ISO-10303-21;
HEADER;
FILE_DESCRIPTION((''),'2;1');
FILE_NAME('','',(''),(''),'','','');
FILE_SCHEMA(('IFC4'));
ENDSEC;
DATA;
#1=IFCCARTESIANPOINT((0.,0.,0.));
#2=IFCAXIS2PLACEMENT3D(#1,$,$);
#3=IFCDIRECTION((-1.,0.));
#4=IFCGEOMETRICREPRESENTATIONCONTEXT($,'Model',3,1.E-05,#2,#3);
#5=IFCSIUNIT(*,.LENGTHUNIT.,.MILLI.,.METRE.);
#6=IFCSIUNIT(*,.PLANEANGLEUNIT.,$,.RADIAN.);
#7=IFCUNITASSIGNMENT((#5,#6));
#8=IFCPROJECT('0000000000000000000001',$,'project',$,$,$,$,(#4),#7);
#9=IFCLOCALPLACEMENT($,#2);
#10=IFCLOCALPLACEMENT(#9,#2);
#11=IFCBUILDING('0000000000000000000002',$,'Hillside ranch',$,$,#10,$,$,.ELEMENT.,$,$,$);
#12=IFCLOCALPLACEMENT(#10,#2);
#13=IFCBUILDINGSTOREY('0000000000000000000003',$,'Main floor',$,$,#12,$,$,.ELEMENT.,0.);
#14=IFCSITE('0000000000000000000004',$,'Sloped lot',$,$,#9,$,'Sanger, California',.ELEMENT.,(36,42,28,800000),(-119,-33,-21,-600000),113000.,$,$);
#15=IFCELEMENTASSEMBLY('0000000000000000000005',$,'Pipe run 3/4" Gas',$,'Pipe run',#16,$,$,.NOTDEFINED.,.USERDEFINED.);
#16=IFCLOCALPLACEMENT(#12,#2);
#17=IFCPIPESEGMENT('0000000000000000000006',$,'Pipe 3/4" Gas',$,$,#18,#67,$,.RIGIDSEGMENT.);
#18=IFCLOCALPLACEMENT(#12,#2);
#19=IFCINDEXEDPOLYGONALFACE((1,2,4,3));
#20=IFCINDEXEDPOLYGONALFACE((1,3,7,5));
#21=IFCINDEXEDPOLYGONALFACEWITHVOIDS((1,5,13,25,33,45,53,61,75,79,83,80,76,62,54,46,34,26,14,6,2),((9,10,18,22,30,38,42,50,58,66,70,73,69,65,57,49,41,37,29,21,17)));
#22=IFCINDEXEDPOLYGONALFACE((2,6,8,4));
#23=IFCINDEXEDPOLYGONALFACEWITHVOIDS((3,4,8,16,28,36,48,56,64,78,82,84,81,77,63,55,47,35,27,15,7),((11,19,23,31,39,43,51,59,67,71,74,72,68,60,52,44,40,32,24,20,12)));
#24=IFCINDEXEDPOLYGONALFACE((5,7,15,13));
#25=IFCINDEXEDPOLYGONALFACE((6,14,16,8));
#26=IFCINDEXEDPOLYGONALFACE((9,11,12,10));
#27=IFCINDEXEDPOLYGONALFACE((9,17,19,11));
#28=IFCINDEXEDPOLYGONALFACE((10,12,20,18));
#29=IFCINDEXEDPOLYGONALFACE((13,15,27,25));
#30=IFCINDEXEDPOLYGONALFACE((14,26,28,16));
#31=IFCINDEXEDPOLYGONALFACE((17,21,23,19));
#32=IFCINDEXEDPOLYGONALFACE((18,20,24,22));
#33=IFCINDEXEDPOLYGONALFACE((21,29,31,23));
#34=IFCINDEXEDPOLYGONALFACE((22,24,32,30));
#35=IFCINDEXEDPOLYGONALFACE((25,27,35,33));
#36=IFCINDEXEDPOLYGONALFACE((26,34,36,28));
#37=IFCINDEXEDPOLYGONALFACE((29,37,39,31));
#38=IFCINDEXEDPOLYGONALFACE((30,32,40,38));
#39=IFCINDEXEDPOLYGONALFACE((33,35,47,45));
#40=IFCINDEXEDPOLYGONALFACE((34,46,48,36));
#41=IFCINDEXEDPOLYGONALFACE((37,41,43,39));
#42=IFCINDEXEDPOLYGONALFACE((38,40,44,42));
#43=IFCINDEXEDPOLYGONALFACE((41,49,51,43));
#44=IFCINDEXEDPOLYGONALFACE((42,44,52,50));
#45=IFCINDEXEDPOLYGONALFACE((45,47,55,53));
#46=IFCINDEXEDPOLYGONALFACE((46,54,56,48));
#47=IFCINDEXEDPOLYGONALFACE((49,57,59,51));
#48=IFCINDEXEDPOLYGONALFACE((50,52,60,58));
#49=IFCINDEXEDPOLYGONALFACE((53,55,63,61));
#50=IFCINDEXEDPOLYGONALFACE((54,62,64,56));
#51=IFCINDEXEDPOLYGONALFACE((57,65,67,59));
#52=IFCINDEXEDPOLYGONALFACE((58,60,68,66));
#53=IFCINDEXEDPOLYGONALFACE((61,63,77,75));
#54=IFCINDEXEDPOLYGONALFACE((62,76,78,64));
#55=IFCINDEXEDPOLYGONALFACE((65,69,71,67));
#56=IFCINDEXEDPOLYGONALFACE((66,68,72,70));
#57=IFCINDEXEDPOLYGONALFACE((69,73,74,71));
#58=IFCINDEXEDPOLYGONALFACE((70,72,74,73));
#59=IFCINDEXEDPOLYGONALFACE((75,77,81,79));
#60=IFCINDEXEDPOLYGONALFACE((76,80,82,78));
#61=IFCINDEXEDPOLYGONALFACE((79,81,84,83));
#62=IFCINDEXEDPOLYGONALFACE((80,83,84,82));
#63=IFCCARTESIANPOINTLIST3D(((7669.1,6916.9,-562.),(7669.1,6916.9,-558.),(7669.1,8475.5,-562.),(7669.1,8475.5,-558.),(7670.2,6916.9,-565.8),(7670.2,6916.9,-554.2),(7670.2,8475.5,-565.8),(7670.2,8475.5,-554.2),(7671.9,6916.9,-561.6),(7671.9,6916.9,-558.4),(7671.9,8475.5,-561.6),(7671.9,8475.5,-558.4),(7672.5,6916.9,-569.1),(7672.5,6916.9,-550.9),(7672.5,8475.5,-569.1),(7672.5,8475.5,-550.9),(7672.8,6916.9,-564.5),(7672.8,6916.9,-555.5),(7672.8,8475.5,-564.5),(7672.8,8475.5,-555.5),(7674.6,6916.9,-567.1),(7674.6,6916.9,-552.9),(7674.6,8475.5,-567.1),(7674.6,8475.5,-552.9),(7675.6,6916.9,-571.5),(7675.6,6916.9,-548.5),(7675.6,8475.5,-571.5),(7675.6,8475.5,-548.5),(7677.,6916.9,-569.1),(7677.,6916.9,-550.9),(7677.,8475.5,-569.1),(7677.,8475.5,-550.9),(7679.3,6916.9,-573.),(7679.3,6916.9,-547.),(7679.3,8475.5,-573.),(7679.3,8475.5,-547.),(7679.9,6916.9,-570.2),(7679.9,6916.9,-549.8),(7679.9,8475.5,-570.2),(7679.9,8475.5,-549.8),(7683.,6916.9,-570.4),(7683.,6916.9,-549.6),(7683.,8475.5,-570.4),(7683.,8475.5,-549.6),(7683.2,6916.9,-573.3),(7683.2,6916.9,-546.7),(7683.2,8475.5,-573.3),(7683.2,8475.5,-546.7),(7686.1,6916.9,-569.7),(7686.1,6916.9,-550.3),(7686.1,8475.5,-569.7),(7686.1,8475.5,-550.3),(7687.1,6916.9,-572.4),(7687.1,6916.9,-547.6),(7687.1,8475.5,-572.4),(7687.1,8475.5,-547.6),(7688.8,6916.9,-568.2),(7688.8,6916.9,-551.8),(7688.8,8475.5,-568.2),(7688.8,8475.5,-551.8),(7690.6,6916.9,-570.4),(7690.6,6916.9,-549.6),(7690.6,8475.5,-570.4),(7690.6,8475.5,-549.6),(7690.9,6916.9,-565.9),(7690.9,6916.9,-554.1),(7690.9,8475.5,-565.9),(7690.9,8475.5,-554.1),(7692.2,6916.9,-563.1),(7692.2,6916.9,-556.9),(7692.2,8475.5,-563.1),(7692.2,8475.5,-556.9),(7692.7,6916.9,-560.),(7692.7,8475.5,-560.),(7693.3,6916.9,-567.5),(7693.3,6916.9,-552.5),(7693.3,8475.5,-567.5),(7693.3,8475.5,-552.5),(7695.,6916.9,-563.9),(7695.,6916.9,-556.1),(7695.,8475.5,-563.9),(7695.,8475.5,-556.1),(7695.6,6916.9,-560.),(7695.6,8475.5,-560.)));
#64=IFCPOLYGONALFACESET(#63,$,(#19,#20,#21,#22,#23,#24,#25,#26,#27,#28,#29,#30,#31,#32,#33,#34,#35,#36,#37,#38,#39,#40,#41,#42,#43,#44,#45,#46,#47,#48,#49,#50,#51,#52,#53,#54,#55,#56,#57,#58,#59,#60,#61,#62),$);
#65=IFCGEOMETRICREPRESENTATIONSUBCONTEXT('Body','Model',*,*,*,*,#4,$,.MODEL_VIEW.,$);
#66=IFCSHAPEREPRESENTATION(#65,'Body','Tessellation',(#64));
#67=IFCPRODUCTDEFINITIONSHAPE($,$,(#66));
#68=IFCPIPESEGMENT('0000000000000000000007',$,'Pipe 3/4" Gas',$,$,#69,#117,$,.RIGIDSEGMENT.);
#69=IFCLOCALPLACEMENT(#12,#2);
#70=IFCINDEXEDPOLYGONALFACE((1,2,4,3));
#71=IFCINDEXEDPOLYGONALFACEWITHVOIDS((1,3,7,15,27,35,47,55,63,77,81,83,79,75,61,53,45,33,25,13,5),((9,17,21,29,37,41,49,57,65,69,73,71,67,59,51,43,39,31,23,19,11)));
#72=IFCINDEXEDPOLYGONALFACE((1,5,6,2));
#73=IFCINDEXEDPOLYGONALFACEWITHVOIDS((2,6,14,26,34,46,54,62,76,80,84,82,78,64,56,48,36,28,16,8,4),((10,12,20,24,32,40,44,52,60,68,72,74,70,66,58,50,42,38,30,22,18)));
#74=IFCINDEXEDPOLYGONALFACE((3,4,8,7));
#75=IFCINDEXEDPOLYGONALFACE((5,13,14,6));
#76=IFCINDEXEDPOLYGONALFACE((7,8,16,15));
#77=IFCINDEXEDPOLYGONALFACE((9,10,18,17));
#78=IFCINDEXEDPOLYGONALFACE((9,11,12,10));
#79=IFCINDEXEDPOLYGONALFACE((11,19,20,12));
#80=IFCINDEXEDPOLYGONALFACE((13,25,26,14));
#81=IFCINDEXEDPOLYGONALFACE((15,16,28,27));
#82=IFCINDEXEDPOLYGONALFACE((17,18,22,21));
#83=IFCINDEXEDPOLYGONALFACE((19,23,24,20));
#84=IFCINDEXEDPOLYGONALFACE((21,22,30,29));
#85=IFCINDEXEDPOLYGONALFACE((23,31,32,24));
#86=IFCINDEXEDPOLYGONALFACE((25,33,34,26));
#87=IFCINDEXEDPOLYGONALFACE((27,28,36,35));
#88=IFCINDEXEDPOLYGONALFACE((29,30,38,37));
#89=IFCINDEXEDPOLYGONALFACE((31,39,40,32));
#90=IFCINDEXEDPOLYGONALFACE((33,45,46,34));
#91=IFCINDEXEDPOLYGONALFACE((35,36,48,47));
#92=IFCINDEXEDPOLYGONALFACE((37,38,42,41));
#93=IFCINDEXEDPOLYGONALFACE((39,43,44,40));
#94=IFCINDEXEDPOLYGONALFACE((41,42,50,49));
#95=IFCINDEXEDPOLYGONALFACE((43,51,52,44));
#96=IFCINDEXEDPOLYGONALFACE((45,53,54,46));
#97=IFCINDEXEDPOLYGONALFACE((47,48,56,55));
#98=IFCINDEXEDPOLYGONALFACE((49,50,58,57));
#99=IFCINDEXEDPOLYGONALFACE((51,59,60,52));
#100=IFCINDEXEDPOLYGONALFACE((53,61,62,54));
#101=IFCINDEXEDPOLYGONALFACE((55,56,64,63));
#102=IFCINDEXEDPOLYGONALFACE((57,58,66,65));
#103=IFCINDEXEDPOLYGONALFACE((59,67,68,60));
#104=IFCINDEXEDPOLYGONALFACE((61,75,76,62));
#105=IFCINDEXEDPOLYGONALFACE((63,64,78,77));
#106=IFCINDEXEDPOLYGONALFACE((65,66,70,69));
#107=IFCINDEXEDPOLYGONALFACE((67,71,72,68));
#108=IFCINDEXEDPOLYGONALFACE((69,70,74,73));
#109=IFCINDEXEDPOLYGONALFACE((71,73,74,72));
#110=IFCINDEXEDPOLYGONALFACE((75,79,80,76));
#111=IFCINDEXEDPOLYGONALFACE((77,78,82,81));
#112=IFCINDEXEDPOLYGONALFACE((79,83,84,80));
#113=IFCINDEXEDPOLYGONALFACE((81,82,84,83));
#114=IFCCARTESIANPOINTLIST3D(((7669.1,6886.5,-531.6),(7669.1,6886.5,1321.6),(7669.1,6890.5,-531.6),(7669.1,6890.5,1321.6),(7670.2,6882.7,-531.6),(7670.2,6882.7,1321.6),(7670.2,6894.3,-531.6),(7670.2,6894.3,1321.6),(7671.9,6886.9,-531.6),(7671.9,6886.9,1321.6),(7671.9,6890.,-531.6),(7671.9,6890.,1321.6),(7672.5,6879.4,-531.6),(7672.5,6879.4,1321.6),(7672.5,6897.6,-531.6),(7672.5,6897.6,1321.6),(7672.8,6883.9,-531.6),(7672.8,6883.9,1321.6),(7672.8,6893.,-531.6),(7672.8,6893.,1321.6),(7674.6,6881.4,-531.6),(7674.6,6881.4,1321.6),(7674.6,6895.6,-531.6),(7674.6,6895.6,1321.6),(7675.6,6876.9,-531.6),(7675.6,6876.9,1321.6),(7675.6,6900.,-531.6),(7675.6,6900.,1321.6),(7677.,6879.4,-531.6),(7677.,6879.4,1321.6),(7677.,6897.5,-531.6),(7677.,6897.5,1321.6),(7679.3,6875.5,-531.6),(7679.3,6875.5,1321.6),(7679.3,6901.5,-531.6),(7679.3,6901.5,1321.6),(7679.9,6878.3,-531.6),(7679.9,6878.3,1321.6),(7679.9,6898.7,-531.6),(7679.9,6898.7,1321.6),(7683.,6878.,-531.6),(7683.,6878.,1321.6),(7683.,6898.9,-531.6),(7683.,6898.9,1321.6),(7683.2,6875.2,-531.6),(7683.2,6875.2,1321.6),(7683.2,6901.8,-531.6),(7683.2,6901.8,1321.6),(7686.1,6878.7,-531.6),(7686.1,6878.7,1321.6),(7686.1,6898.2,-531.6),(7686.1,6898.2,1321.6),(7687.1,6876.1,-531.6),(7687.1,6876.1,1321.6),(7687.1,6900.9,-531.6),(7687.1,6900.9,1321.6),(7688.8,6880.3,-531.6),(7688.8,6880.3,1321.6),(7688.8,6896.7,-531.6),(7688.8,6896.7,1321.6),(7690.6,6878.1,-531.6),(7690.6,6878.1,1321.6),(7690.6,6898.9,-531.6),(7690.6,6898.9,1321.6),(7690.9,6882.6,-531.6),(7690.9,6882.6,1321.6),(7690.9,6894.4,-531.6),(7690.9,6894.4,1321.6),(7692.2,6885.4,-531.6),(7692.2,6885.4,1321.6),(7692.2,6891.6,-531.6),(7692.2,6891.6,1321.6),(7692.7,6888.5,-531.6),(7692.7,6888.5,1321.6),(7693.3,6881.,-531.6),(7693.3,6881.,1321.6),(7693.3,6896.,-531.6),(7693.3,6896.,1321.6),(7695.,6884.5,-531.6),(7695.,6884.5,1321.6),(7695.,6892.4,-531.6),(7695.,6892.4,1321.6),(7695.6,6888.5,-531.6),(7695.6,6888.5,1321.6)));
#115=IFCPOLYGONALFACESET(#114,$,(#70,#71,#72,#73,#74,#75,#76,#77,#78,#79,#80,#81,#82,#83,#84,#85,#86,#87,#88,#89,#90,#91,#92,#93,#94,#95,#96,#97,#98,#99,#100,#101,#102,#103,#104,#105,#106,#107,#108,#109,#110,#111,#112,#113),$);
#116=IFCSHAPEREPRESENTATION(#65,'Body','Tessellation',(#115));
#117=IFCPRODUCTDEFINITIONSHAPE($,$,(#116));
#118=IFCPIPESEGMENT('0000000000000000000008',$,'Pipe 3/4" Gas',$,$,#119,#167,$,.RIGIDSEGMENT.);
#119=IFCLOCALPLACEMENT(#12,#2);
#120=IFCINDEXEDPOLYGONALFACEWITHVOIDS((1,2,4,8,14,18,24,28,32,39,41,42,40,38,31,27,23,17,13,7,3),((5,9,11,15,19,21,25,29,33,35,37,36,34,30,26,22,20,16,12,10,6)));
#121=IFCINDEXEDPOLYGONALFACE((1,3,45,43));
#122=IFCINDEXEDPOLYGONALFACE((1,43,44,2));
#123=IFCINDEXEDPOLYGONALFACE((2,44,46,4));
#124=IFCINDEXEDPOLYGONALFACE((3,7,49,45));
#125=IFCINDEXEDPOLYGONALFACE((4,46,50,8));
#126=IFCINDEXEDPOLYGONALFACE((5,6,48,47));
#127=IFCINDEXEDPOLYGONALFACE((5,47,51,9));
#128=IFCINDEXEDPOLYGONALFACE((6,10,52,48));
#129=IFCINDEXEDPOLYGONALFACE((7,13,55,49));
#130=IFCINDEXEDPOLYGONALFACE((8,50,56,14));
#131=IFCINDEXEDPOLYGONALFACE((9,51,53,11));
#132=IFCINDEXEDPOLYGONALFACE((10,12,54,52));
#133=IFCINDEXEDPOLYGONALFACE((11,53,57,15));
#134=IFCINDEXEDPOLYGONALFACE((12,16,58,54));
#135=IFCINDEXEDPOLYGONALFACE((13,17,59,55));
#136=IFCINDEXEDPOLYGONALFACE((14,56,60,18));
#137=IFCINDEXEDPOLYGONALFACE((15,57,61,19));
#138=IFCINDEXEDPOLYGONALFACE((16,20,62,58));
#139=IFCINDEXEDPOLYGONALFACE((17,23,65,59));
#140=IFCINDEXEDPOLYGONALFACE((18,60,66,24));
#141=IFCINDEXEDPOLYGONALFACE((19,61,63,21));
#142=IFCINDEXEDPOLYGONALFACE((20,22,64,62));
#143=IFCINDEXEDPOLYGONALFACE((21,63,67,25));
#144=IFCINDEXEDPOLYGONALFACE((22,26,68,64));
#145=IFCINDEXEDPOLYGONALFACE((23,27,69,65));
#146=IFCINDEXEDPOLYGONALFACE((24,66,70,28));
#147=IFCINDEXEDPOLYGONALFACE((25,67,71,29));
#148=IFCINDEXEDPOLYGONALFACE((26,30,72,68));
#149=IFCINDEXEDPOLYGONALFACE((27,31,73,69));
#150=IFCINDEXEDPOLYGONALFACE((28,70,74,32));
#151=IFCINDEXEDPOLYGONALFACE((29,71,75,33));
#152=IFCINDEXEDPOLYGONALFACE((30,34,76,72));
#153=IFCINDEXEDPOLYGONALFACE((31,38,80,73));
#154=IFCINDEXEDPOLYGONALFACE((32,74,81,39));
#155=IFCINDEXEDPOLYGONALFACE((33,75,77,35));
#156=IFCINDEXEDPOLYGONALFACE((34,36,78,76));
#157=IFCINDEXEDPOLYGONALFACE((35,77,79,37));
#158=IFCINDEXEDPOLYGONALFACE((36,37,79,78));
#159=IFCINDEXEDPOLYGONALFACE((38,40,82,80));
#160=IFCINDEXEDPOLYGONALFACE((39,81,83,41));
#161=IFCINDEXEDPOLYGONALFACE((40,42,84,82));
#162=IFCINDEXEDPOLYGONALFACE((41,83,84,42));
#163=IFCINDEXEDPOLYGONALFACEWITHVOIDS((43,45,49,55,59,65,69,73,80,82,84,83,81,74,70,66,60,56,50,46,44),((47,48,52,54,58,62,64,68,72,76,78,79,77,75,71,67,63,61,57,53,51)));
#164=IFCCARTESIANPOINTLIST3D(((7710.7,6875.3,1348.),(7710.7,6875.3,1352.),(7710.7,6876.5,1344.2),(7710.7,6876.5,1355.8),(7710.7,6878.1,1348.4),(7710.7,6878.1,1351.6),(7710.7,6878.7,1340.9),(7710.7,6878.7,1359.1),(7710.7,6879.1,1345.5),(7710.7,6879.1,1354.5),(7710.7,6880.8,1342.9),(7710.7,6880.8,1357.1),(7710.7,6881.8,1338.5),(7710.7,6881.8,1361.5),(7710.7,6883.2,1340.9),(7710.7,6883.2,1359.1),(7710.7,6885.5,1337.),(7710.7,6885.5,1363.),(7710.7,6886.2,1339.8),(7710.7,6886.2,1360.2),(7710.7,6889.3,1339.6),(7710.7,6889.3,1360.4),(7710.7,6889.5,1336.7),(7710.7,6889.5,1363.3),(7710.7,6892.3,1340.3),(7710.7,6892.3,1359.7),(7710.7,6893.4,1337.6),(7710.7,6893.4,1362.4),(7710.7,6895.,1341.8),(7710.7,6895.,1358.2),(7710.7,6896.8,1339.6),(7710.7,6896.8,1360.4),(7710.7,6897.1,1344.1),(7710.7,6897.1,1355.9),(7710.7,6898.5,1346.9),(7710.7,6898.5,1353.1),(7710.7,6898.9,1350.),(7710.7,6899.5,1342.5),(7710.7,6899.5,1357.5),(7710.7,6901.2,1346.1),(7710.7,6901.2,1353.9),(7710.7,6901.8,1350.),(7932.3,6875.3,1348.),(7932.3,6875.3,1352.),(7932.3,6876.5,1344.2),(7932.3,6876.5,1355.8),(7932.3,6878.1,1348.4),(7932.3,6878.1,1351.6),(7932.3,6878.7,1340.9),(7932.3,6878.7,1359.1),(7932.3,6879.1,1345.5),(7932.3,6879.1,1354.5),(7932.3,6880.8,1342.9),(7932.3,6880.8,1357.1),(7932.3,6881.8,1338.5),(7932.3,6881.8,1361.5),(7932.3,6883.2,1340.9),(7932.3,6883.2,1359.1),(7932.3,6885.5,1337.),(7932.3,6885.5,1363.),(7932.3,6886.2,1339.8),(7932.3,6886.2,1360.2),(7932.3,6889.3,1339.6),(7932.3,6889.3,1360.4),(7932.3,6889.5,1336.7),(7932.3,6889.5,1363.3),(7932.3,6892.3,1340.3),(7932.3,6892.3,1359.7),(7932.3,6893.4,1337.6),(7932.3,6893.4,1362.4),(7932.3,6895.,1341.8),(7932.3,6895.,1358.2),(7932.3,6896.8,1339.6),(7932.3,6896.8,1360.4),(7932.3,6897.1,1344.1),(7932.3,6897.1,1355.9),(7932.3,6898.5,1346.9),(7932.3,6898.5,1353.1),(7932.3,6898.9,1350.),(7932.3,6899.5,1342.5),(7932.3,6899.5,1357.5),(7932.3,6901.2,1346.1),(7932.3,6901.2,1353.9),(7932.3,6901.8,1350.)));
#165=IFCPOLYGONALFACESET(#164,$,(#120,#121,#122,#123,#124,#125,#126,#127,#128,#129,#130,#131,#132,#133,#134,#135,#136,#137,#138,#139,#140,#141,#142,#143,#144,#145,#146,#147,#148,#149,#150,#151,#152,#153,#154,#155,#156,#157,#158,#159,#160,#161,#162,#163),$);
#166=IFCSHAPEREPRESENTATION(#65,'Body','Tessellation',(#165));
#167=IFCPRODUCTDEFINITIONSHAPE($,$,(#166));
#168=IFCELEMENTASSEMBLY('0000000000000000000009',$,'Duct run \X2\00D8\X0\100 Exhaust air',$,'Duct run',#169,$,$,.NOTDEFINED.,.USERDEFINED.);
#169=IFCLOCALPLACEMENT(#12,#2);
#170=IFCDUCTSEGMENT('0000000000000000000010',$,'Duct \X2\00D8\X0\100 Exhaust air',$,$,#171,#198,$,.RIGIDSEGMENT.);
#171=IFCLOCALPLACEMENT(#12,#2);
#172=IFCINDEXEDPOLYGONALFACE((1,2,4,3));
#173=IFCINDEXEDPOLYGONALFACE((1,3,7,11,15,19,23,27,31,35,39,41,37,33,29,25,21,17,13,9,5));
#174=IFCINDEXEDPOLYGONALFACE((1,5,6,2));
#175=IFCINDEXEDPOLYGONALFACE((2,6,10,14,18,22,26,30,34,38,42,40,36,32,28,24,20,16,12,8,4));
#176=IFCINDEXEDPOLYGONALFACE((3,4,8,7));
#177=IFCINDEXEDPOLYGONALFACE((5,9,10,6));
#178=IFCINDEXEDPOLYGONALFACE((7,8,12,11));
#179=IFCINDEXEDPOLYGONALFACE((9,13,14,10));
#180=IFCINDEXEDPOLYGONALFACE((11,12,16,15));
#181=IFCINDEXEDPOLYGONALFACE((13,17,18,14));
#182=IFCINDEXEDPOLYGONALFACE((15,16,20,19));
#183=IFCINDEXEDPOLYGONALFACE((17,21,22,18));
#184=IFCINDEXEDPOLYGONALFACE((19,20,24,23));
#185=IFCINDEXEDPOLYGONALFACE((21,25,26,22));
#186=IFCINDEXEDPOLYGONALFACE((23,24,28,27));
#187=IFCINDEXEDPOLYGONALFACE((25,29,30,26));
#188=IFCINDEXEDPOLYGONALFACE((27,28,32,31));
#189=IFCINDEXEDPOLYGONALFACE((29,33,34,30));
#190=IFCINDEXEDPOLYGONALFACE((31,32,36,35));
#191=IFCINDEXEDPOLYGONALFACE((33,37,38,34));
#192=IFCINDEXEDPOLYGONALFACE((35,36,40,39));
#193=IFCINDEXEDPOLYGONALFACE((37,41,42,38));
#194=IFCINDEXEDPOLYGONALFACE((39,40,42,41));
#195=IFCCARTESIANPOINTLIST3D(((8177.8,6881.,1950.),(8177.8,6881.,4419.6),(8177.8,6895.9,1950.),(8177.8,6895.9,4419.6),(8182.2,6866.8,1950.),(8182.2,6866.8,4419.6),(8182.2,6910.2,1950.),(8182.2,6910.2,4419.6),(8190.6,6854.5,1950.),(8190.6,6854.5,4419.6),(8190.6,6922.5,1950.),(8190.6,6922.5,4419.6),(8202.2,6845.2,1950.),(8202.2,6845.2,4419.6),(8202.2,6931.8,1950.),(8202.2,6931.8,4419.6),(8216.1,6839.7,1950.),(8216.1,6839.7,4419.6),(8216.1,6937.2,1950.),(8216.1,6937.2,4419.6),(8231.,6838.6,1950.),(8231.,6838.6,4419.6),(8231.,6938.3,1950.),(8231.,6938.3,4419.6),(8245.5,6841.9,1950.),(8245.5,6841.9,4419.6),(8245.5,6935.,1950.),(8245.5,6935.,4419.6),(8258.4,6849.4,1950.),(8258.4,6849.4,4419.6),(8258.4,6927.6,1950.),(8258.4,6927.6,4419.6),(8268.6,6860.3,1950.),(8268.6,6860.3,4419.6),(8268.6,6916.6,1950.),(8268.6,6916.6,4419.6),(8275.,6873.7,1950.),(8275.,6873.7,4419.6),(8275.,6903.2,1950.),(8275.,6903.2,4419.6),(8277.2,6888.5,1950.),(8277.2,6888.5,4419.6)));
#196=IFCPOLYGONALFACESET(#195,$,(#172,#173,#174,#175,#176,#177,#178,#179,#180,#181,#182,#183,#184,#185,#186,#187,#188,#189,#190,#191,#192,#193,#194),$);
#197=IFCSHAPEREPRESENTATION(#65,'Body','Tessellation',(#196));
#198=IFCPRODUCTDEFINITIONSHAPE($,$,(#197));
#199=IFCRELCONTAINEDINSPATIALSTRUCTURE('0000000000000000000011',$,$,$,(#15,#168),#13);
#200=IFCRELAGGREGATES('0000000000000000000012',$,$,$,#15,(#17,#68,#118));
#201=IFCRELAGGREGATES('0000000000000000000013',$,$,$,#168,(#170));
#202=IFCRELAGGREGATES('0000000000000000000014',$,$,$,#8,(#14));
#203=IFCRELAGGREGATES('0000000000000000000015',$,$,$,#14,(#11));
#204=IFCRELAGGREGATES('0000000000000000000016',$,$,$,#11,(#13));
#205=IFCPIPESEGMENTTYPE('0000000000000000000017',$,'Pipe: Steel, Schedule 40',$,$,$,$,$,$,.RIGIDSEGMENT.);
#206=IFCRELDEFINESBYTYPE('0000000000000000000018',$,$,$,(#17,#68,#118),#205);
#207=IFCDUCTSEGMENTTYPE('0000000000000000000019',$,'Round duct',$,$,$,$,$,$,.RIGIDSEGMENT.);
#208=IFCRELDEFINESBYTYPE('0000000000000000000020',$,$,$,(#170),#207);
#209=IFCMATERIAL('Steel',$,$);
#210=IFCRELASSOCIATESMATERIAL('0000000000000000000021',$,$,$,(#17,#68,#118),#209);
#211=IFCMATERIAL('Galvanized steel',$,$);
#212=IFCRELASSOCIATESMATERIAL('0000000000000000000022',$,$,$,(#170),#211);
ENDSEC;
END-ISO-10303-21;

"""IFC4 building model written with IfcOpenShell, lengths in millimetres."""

from ifc_helpers import new_model, si_unit, direction, frame, origin, origin_with_axes, origin_2d, place, context, subcontext, project, spatial, circle, hollow_circle, extrude, material, type_object, element, aggregate, save


model = new_model("IFC4")

# Units and contexts
model_context = context("Model", 3, precision=1e-05, world=origin(), true_north=direction((-1.0, 0.0)))
body_context = subcontext(model_context, "Body", "Model", "MODEL_VIEW")
ifc_project = project(units=[si_unit("LENGTHUNIT", "METRE", prefix="MILLI"), si_unit("PLANEANGLEUNIT", "RADIAN")], contexts=[model_context])

# Site, building, storey
site_placement = place(None, origin())
site = spatial("IfcSite", under=ifc_project, at=site_placement, Name="Sloped lot", LongName="Sanger, California", CompositionType="ELEMENT", RefLatitude=(36, 42, 28, 800000), RefLongitude=(-119, -33, -21, -600000), RefElevation=113000.0)
building_placement = place(site_placement, origin())
building = spatial("IfcBuilding", under=site, at=building_placement, Name="Hillside ranch", CompositionType="ELEMENT")
storey_placement = place(building_placement, origin())
storey = spatial("IfcBuildingStorey", under=building, at=storey_placement, Name="Main floor", CompositionType="ELEMENT", Elevation=0.0)

# Element assembly, pipe segments
assembly_1_placement = place(storey_placement, origin_with_axes())
assembly_1 = element("IfcElementAssembly", 1, at=assembly_1_placement, inside=storey, Name="Pipe run 3/4\" Gas", ObjectType="Pipe run", AssemblyPlace="NOTDEFINED", PredefinedType="USERDEFINED")
ifc_material_1 = material(Name="Steel")
pipe_segment_type = type_object("IfcPipeSegmentType", Name="Pipe: Steel, Schedule 40", PredefinedType="RIGIDSEGMENT")
pipe_segment_1_placement = place(storey_placement, origin_with_axes())
pipe_segment_1 = element("IfcPipeSegment", 2, at=pipe_segment_1_placement, type_object=pipe_segment_type, material=ifc_material_1, Name="Pipe 3/4\" Gas", PredefinedType="RIGIDSEGMENT", context=body_context, shape_type="SweptSolid", body=[
    extrude(hollow_circle(Radius=13.3, WallThickness=2.9, at=origin_2d()), frame((7682.2, 8475.5, -560.0), z_axis=(0.0, -1.0, 0.0), x_axis=(1.0, 0.0, 0.0)), (0.0, 0.0, 1.0), 1558.5),
])
pipe_segment_2_placement = place(storey_placement, origin_with_axes())
pipe_segment_2 = element("IfcPipeSegment", 3, at=pipe_segment_2_placement, type_object=pipe_segment_type, material=ifc_material_1, Name="Pipe 3/4\" Gas", PredefinedType="RIGIDSEGMENT", context=body_context, shape_type="SweptSolid", body=[
    extrude(hollow_circle(Radius=13.3, WallThickness=2.9, at=origin_2d()), frame((7682.2, 6888.5, -531.6), z_axis=(0.0, 0.0, 1.0), x_axis=(1.0, 0.0, 0.0)), (0.0, 0.0, 1.0), 1853.1),
])
pipe_segment_3_placement = place(storey_placement, origin_with_axes())
pipe_segment_3 = element("IfcPipeSegment", 4, at=pipe_segment_3_placement, type_object=pipe_segment_type, material=ifc_material_1, Name="Pipe 3/4\" Gas", PredefinedType="RIGIDSEGMENT", context=body_context, shape_type="SweptSolid", body=[
    extrude(hollow_circle(Radius=13.3, WallThickness=2.9, at=origin_2d()), frame((7710.7, 6888.5, 1350.0), z_axis=(1.0, 0.0, 0.0), x_axis=(0.0, 1.0, 0.0)), (0.0, 0.0, 1.0), 221.6),
])
aggregate(assembly_1, [pipe_segment_1, pipe_segment_2, pipe_segment_3])

# Element assembly, duct segment
assembly_2_placement = place(storey_placement, origin_with_axes())
assembly_2 = element("IfcElementAssembly", 5, at=assembly_2_placement, inside=storey, Name="Duct run Ø100 Exhaust air", ObjectType="Duct run", AssemblyPlace="NOTDEFINED", PredefinedType="USERDEFINED")
ifc_material_2 = material(Name="Galvanized steel")
duct_segment_type = type_object("IfcDuctSegmentType", Name="Round duct", PredefinedType="RIGIDSEGMENT")
duct_segment_placement = place(storey_placement, origin_with_axes())
duct_segment = element("IfcDuctSegment", 6, at=duct_segment_placement, type_object=duct_segment_type, material=ifc_material_2, Name="Duct Ø100 Exhaust air", PredefinedType="RIGIDSEGMENT", context=body_context, shape_type="SweptSolid", body=[
    extrude(circle(Radius=50.0, at=origin_2d()), frame((8227.2, 6888.5, 1950.0), z_axis=(0.0, 0.0, 1.0), x_axis=(1.0, 0.0, 0.0)), (0.0, 0.0, 1.0), 2469.6),
])
aggregate(assembly_2, [duct_segment])

save(model, "model.ifc")
